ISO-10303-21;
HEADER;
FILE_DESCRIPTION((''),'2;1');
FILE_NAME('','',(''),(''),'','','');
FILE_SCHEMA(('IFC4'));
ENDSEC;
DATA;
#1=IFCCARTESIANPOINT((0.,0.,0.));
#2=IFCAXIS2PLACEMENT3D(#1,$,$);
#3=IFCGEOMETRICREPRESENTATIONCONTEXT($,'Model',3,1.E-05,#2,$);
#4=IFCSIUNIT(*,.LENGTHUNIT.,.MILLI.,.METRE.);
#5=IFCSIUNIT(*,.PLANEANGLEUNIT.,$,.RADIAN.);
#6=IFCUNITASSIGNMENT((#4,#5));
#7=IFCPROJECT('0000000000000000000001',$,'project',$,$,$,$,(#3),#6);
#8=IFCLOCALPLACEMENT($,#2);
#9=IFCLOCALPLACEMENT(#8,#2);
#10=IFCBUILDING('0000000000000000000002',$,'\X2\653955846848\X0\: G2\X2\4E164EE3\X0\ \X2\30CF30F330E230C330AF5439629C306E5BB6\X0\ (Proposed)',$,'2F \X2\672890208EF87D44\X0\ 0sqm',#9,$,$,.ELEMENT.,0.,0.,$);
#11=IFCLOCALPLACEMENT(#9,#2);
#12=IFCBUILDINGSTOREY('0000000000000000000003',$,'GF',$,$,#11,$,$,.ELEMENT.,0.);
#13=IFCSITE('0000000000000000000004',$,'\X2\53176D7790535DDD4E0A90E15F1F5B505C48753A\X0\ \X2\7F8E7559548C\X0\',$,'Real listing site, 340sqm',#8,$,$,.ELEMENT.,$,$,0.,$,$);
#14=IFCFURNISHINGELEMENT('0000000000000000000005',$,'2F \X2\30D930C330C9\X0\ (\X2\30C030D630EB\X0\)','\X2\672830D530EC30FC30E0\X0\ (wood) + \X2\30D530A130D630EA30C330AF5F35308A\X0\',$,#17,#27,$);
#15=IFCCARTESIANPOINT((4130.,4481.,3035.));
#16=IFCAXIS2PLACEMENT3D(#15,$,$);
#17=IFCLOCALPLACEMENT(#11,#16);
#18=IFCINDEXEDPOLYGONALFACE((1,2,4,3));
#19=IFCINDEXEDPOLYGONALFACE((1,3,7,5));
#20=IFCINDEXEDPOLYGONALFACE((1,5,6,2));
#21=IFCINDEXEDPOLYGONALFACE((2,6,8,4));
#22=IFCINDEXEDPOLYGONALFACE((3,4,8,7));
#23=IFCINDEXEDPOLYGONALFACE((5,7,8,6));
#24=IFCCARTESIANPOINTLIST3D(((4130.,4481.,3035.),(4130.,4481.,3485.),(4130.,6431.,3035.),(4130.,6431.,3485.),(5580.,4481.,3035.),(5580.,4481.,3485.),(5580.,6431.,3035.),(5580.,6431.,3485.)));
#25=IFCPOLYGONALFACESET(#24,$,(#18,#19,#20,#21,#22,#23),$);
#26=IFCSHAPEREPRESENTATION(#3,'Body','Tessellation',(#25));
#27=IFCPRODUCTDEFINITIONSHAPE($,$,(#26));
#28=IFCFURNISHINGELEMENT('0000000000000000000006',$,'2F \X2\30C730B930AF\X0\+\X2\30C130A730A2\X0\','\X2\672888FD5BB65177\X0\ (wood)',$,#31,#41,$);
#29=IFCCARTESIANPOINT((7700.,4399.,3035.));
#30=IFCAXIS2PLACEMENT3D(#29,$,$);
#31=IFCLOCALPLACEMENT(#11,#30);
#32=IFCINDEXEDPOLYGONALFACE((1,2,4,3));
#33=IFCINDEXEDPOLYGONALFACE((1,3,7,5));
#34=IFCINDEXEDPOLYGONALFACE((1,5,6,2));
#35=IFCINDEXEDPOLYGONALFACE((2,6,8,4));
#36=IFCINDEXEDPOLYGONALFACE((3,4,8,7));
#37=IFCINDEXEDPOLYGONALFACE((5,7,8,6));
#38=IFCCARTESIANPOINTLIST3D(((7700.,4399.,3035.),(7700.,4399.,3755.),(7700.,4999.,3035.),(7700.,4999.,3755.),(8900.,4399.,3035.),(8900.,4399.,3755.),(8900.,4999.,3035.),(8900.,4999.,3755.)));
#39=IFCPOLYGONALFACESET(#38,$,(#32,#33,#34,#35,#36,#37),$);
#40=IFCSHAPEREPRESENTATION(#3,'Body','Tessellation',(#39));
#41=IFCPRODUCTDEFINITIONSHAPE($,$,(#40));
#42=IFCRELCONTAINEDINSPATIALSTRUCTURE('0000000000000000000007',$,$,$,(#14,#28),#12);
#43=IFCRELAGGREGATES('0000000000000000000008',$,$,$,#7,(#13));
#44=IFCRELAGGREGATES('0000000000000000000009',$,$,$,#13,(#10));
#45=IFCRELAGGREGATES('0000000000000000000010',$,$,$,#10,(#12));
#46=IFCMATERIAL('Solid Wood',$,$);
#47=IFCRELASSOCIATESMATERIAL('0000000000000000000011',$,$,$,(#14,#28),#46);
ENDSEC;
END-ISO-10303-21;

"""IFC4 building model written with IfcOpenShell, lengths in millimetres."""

from ifc_helpers import new_model, si_unit, frame, frame_2d, origin, place, context, project, spatial, rectangle, extrude, material, element, save


model = new_model("IFC4")

# Units and contexts
model_context = context("Model", 3, precision=1e-05, world=origin())
ifc_project = project(units=[si_unit("LENGTHUNIT", "METRE", prefix="MILLI"), si_unit("PLANEANGLEUNIT", "RADIAN")], contexts=[model_context])

# Site, building, storey
site_placement = place(None, origin())
site = spatial("IfcSite", under=ifc_project, at=site_placement, Name="北海道川上郡弟子屈町 美留和", ObjectType="Real listing site, 340sqm", CompositionType="ELEMENT", RefElevation=0.0)
building_placement = place(site_placement, origin())
building = spatial("IfcBuilding", under=site, at=building_placement, Name="改善案: G2世代 ハンモック吹抜の家 (Proposed)", ObjectType="2F 木造軸組 0sqm", CompositionType="ELEMENT", ElevationOfRefHeight=0.0, ElevationOfTerrain=0.0)
storey_placement = place(building_placement, origin())
storey = spatial("IfcBuildingStorey", under=building, at=storey_placement, Name="GF", CompositionType="ELEMENT", Elevation=0.0)

# Shared definitions
ifc_material_1 = material(Name="Solid Wood")

# Furnishing elements
furnishing_1_placement = place(storey_placement, frame((4130.0, 4481.0, 3035.0)))
element("IfcFurnishingElement", 1, at=furnishing_1_placement, inside=storey, material=ifc_material_1, Name="2F ベッド (ダブル)", Description="木フレーム (wood) + ファブリック張り", context=model_context, shape_type="SweptSolid", body=[
    extrude(rectangle(XDim=1450.0, YDim=1950.0, at=frame_2d((725.0, 975.0))), frame((4130.0, 4481.0, 3035.0)), (0.0, 0.0, 1.0), 450.0),
])
furnishing_2_placement = place(storey_placement, frame((7700.0, 4399.0, 3035.0)))
element("IfcFurnishingElement", 2, at=furnishing_2_placement, inside=storey, material=ifc_material_1, Name="2F デスク+チェア", Description="木製家具 (wood)", context=model_context, shape_type="SweptSolid", body=[
    extrude(rectangle(XDim=1200.0, YDim=600.0, at=frame_2d((600.0, 300.0))), frame((7700.0, 4399.0, 3035.0)), (0.0, 0.0, 1.0), 720.0),
])

save(model, "model.ifc")
